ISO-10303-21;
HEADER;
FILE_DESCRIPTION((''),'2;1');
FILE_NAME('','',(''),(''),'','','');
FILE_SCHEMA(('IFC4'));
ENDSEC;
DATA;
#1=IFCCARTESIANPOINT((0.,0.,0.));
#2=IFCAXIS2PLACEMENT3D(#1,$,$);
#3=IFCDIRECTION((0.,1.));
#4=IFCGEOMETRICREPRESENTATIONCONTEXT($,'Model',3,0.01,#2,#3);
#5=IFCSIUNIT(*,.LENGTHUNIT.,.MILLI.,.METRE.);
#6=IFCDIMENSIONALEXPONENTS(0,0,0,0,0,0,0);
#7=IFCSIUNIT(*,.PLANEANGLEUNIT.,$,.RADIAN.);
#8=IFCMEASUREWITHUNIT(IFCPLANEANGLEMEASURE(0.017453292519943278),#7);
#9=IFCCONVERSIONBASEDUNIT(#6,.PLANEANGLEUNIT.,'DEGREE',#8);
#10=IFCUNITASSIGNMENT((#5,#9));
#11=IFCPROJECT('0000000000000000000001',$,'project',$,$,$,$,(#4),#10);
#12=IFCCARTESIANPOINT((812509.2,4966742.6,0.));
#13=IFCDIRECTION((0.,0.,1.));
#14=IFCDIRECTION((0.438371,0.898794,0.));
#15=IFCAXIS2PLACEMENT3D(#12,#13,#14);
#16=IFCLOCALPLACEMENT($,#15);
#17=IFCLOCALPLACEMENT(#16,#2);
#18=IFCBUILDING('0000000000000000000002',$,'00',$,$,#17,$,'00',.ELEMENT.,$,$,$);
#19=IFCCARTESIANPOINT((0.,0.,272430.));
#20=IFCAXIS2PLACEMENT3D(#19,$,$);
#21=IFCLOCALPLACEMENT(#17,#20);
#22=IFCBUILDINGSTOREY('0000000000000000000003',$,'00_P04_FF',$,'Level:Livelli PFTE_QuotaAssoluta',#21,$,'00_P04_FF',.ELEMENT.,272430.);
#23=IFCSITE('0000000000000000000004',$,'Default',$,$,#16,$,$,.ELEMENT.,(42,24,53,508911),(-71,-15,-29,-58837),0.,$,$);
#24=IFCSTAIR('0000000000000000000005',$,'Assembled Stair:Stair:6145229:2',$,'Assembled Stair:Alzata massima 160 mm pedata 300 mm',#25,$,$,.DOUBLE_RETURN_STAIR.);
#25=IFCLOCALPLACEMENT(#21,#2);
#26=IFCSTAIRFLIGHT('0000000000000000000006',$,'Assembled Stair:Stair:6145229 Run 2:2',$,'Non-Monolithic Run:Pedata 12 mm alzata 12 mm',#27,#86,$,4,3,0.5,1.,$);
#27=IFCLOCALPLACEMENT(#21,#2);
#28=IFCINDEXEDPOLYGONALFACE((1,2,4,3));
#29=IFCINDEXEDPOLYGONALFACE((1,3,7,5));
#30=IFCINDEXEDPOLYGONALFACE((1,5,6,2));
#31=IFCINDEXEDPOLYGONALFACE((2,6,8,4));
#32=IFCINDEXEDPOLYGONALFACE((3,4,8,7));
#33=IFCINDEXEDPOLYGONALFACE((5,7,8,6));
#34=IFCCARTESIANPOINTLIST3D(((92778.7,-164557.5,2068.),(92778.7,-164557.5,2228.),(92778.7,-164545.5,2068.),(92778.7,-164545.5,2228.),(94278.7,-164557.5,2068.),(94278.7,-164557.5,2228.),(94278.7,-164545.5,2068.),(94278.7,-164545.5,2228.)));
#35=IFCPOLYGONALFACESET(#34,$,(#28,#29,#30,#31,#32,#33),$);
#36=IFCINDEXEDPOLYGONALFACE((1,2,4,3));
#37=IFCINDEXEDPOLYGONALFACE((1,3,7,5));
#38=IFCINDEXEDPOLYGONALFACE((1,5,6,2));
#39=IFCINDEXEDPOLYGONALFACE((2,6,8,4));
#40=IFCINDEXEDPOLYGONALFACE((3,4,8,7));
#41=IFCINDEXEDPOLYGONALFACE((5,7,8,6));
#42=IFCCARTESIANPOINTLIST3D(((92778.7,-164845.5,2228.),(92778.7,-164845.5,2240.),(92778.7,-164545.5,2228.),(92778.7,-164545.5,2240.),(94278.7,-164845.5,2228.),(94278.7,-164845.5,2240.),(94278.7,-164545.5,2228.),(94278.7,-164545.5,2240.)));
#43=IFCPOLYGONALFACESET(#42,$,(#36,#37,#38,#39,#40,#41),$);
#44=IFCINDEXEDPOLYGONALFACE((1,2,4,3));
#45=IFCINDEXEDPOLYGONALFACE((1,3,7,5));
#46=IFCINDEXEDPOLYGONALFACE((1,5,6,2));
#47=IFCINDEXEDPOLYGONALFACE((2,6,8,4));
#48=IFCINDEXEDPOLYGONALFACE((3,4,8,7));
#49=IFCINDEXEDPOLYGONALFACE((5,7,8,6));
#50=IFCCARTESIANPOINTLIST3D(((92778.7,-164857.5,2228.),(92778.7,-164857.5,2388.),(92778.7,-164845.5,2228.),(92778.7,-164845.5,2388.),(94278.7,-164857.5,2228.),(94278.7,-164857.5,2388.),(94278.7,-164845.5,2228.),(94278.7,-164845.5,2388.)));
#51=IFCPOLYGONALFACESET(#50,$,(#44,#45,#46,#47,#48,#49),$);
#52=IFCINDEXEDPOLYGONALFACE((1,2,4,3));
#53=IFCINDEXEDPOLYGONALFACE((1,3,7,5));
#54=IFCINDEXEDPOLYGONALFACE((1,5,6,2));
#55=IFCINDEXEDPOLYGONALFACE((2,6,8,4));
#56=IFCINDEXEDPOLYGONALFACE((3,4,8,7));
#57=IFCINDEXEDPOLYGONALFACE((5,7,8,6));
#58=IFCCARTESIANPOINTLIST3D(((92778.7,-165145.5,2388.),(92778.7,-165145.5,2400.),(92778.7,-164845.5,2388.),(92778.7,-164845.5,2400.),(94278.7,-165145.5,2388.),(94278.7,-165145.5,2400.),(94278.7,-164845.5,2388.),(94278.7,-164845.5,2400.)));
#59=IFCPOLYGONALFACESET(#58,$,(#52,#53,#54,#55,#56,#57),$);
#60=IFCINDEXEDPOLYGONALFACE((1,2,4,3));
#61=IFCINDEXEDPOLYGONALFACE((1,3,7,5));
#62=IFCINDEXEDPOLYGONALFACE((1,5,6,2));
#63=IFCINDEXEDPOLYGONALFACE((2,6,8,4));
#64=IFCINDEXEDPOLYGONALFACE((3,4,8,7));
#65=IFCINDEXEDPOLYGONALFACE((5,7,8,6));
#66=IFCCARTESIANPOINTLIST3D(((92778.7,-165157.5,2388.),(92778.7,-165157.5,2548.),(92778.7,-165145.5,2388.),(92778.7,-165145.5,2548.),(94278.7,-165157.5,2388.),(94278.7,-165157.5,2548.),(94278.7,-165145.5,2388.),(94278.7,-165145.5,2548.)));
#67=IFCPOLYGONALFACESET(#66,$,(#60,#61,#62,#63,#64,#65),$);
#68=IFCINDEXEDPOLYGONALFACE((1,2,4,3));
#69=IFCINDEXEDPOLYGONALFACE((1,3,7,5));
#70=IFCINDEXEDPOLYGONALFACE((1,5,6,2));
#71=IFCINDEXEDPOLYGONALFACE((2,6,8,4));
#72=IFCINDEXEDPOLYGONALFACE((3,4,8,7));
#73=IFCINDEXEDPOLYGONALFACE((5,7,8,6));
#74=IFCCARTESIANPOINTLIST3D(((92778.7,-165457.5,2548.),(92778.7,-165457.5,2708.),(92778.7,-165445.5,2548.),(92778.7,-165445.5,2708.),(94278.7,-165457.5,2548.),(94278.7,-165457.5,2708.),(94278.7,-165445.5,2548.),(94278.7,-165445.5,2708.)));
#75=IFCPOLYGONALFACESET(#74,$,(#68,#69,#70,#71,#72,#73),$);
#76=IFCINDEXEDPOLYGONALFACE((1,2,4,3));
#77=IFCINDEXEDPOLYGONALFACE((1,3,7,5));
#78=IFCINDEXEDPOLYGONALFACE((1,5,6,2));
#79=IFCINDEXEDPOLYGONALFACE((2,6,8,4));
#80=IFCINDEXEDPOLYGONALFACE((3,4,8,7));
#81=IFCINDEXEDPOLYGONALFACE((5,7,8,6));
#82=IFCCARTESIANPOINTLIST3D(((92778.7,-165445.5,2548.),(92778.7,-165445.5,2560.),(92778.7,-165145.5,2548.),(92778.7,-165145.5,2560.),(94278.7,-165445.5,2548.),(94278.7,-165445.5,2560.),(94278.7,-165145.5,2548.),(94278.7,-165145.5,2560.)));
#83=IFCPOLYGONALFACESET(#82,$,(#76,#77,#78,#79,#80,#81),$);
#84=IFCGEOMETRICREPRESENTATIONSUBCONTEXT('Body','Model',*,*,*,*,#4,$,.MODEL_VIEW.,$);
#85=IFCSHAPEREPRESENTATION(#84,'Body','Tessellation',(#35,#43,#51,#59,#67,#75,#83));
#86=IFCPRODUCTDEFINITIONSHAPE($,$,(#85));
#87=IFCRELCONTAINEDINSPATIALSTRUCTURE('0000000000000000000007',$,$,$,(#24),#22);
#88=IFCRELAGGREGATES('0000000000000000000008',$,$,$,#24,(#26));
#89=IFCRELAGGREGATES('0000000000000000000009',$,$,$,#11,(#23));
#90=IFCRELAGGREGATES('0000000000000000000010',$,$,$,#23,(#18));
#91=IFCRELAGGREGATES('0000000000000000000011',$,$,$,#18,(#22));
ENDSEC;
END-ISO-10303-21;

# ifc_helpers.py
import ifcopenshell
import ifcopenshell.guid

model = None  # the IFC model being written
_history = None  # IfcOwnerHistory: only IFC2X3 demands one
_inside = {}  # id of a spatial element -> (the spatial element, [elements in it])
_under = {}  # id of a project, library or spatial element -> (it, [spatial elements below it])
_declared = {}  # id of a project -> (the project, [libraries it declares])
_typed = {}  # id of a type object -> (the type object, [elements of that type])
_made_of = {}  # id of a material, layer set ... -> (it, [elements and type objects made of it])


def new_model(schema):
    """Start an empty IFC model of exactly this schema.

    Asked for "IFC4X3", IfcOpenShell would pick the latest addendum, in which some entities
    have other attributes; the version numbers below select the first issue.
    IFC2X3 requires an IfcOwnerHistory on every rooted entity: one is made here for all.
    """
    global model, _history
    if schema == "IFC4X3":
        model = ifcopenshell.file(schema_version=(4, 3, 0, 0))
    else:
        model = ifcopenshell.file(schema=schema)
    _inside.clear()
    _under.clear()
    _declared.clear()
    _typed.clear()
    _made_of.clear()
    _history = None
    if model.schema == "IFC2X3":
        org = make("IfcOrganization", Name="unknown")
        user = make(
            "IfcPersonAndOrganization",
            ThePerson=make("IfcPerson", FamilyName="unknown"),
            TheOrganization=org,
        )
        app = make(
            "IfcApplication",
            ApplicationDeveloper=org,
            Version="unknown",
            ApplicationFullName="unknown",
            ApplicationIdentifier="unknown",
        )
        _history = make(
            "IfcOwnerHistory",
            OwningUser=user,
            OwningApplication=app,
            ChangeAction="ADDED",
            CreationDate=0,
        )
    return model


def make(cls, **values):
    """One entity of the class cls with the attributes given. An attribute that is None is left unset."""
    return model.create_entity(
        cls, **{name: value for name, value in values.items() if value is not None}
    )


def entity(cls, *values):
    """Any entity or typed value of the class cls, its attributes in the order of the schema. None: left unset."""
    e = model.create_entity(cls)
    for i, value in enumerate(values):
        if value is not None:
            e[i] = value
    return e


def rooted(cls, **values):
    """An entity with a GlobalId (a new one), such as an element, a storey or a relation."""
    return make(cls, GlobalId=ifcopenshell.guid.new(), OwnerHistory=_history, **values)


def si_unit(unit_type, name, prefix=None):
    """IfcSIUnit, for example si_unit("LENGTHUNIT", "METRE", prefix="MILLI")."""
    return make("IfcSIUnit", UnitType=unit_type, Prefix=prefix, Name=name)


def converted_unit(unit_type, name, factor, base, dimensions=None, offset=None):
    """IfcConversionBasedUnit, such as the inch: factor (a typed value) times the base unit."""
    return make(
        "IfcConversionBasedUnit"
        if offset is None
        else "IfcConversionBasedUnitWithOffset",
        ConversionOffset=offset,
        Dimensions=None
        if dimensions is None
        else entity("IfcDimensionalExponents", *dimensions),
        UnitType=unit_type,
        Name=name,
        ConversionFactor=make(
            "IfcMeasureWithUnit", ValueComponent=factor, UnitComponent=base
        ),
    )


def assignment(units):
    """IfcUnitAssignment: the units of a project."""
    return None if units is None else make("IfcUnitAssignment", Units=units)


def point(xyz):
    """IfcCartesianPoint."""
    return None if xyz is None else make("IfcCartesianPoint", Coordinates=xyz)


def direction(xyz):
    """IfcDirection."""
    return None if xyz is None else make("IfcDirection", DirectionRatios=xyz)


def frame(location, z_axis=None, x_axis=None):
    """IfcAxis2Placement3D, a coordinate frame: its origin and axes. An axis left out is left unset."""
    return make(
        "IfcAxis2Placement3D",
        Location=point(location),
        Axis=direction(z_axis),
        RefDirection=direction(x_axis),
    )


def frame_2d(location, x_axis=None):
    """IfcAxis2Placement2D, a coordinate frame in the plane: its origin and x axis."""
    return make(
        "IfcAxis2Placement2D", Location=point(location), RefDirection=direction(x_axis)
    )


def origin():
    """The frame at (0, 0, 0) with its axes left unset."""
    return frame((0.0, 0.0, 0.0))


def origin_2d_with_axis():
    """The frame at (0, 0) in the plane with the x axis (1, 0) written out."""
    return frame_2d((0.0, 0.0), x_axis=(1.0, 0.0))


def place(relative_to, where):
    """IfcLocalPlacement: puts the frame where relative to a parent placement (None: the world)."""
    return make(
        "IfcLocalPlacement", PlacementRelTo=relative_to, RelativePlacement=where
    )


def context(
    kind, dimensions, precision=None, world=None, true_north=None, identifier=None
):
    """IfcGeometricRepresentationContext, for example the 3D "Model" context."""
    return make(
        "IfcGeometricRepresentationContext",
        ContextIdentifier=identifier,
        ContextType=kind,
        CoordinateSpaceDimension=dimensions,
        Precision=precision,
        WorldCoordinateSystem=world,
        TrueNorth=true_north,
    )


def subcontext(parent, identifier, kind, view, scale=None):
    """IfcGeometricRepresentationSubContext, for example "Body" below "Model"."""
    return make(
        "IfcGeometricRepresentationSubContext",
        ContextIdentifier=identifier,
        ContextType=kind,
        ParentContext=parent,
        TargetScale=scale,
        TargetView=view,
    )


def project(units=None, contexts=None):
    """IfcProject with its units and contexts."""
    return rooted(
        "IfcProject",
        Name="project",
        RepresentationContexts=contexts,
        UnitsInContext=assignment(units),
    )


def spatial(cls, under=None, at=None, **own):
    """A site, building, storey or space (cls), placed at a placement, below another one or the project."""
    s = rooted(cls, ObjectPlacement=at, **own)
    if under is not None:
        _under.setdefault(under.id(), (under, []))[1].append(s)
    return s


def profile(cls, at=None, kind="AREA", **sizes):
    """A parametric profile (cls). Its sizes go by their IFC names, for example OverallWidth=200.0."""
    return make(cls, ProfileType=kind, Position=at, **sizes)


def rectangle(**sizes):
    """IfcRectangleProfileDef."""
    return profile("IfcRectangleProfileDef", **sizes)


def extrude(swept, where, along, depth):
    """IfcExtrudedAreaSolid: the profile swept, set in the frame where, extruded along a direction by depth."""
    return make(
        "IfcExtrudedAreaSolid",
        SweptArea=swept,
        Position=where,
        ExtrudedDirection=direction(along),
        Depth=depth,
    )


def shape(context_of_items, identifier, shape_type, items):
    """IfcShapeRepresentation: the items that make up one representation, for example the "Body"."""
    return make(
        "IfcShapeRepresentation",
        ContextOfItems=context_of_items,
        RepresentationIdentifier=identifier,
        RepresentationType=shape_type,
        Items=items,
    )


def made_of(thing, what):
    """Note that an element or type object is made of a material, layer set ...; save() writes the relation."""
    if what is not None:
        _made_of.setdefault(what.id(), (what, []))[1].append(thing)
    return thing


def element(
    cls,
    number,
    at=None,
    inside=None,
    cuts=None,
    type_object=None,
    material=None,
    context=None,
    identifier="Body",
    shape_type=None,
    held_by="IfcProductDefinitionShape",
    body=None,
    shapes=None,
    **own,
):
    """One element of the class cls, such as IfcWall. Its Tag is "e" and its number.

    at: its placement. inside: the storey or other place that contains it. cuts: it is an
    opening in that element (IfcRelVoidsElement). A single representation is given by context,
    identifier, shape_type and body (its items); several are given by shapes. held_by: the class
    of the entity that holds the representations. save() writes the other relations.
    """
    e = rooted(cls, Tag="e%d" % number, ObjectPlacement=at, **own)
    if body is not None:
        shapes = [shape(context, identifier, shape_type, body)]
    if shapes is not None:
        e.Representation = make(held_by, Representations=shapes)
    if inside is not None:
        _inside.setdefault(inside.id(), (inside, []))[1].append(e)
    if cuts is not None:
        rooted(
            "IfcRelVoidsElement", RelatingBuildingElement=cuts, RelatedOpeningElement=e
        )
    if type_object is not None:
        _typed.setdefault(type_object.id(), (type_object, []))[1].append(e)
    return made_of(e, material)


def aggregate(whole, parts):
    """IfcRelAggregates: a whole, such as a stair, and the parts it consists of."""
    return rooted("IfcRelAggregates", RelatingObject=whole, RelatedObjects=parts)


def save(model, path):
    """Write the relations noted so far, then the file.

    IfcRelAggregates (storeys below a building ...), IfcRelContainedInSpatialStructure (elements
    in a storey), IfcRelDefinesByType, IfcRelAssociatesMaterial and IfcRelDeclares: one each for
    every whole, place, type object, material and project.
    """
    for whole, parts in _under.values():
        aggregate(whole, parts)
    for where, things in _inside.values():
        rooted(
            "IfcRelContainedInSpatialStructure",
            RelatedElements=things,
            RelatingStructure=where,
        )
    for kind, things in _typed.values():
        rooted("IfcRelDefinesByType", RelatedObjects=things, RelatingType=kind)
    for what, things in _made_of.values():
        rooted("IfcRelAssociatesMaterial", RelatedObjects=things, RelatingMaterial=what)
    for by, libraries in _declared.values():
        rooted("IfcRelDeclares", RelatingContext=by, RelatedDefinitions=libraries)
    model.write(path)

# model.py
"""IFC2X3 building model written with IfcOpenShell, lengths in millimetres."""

from ifc_helpers import new_model, entity, si_unit, converted_unit, direction, frame, frame_2d, origin, origin_2d_with_axis, place, context, subcontext, project, spatial, rectangle, extrude, element, aggregate, save


model = new_model("IFC2X3")

# Units and contexts
model_context = context("Model", 3, precision=0.01, world=origin(), true_north=direction((0.0, 1.0)))
body_context = subcontext(model_context, "Body", "Model", "MODEL_VIEW")
ifc_project = project(units=[si_unit("LENGTHUNIT", "METRE", prefix="MILLI"), converted_unit("PLANEANGLEUNIT", "DEGREE", entity("IfcPlaneAngleMeasure", 0.017453292519943278), si_unit("PLANEANGLEUNIT", "RADIAN"), dimensions=[0, 0, 0, 0, 0, 0, 0])], contexts=[model_context])

# Site, building, storey
site_placement = place(None, frame((812509.2, 4966742.6, 0.0), z_axis=(0.0, 0.0, 1.0), x_axis=(0.438371, 0.898794, 0.0)))
site = spatial("IfcSite", under=ifc_project, at=site_placement, Name="Default", CompositionType="ELEMENT", RefLatitude=(42, 24, 53, 508911), RefLongitude=(-71, -15, -29, -58837), RefElevation=0.0)
building_placement = place(site_placement, origin())
building = spatial("IfcBuilding", under=site, at=building_placement, Name="00", LongName="00", CompositionType="ELEMENT")
storey_placement = place(building_placement, frame((0.0, 0.0, 272430.0)))
storey = spatial("IfcBuildingStorey", under=building, at=storey_placement, Name="00_P04_FF", ObjectType="Level:Livelli PFTE_QuotaAssoluta", LongName="00_P04_FF", CompositionType="ELEMENT", Elevation=272430.0)

# Stair
stair_1_placement = place(storey_placement, origin())
stair_1 = element("IfcStair", 1, at=stair_1_placement, inside=storey, Name="Assembled Stair:Stair:6145229:2", ObjectType="Assembled Stair:Alzata massima 160 mm pedata 300 mm", ShapeType="DOUBLE_RETURN_STAIR")

# Stair flight
stair_flight_1_placement = place(stair_1_placement, origin())
stair_flight_1 = element("IfcStairFlight", 2, at=stair_flight_1_placement, Name="Assembled Stair:Stair:6145229 Run 2:2", ObjectType="Non-Monolithic Run:Pedata 12 mm alzata 12 mm", NumberOfRiser=4, NumberOfTreads=3, RiserHeight=0.5, TreadLength=1.0, context=body_context, shape_type="SweptSolid", body=[
    extrude(rectangle(XDim=1500.0, YDim=12.0, at=origin_2d_with_axis()), frame((93528.7, -164551.5, 2068.0)), (0.0, 0.0, 1.0), 160.0),
    extrude(rectangle(XDim=300.0, YDim=1500.0, at=origin_2d_with_axis()), frame((93528.7, -164695.5, 2228.0), z_axis=(0.0, 0.0, 1.0), x_axis=(0.0, 1.0, 0.0)), (0.0, 0.0, 1.0), 12.0),
    extrude(rectangle(XDim=1500.0, YDim=12.0, at=origin_2d_with_axis()), frame((93528.7, -164851.5, 2228.0)), (0.0, 0.0, 1.0), 160.0),
    extrude(rectangle(XDim=300.0, YDim=1500.0, at=frame_2d((0.0, 0.0), x_axis=(1.0, 0.0))), frame((93528.7, -164995.5, 2388.0), z_axis=(0.0, 0.0, 1.0), x_axis=(0.0, 1.0, 0.0)), (0.0, 0.0, 1.0), 12.0),
    extrude(rectangle(XDim=1500.0, YDim=12.0, at=origin_2d_with_axis()), frame((93528.7, -165151.5, 2388.0)), (0.0, 0.0, 1.0), 160.0),
    extrude(rectangle(XDim=1500.0, YDim=12.0, at=origin_2d_with_axis()), frame((93528.7, -165451.5, 2548.0)), (0.0, 0.0, 1.0), 160.0),
    extrude(rectangle(XDim=300.0, YDim=1500.0, at=frame_2d((0.0, 0.0), x_axis=(1.0, 0.0))), frame((93528.7, -165295.5, 2548.0), z_axis=(0.0, 0.0, 1.0), x_axis=(0.0, 1.0, 0.0)), (0.0, 0.0, 1.0), 12.0),
])
aggregate(stair_1, [stair_flight_1])

save(model, "model.ifc")
